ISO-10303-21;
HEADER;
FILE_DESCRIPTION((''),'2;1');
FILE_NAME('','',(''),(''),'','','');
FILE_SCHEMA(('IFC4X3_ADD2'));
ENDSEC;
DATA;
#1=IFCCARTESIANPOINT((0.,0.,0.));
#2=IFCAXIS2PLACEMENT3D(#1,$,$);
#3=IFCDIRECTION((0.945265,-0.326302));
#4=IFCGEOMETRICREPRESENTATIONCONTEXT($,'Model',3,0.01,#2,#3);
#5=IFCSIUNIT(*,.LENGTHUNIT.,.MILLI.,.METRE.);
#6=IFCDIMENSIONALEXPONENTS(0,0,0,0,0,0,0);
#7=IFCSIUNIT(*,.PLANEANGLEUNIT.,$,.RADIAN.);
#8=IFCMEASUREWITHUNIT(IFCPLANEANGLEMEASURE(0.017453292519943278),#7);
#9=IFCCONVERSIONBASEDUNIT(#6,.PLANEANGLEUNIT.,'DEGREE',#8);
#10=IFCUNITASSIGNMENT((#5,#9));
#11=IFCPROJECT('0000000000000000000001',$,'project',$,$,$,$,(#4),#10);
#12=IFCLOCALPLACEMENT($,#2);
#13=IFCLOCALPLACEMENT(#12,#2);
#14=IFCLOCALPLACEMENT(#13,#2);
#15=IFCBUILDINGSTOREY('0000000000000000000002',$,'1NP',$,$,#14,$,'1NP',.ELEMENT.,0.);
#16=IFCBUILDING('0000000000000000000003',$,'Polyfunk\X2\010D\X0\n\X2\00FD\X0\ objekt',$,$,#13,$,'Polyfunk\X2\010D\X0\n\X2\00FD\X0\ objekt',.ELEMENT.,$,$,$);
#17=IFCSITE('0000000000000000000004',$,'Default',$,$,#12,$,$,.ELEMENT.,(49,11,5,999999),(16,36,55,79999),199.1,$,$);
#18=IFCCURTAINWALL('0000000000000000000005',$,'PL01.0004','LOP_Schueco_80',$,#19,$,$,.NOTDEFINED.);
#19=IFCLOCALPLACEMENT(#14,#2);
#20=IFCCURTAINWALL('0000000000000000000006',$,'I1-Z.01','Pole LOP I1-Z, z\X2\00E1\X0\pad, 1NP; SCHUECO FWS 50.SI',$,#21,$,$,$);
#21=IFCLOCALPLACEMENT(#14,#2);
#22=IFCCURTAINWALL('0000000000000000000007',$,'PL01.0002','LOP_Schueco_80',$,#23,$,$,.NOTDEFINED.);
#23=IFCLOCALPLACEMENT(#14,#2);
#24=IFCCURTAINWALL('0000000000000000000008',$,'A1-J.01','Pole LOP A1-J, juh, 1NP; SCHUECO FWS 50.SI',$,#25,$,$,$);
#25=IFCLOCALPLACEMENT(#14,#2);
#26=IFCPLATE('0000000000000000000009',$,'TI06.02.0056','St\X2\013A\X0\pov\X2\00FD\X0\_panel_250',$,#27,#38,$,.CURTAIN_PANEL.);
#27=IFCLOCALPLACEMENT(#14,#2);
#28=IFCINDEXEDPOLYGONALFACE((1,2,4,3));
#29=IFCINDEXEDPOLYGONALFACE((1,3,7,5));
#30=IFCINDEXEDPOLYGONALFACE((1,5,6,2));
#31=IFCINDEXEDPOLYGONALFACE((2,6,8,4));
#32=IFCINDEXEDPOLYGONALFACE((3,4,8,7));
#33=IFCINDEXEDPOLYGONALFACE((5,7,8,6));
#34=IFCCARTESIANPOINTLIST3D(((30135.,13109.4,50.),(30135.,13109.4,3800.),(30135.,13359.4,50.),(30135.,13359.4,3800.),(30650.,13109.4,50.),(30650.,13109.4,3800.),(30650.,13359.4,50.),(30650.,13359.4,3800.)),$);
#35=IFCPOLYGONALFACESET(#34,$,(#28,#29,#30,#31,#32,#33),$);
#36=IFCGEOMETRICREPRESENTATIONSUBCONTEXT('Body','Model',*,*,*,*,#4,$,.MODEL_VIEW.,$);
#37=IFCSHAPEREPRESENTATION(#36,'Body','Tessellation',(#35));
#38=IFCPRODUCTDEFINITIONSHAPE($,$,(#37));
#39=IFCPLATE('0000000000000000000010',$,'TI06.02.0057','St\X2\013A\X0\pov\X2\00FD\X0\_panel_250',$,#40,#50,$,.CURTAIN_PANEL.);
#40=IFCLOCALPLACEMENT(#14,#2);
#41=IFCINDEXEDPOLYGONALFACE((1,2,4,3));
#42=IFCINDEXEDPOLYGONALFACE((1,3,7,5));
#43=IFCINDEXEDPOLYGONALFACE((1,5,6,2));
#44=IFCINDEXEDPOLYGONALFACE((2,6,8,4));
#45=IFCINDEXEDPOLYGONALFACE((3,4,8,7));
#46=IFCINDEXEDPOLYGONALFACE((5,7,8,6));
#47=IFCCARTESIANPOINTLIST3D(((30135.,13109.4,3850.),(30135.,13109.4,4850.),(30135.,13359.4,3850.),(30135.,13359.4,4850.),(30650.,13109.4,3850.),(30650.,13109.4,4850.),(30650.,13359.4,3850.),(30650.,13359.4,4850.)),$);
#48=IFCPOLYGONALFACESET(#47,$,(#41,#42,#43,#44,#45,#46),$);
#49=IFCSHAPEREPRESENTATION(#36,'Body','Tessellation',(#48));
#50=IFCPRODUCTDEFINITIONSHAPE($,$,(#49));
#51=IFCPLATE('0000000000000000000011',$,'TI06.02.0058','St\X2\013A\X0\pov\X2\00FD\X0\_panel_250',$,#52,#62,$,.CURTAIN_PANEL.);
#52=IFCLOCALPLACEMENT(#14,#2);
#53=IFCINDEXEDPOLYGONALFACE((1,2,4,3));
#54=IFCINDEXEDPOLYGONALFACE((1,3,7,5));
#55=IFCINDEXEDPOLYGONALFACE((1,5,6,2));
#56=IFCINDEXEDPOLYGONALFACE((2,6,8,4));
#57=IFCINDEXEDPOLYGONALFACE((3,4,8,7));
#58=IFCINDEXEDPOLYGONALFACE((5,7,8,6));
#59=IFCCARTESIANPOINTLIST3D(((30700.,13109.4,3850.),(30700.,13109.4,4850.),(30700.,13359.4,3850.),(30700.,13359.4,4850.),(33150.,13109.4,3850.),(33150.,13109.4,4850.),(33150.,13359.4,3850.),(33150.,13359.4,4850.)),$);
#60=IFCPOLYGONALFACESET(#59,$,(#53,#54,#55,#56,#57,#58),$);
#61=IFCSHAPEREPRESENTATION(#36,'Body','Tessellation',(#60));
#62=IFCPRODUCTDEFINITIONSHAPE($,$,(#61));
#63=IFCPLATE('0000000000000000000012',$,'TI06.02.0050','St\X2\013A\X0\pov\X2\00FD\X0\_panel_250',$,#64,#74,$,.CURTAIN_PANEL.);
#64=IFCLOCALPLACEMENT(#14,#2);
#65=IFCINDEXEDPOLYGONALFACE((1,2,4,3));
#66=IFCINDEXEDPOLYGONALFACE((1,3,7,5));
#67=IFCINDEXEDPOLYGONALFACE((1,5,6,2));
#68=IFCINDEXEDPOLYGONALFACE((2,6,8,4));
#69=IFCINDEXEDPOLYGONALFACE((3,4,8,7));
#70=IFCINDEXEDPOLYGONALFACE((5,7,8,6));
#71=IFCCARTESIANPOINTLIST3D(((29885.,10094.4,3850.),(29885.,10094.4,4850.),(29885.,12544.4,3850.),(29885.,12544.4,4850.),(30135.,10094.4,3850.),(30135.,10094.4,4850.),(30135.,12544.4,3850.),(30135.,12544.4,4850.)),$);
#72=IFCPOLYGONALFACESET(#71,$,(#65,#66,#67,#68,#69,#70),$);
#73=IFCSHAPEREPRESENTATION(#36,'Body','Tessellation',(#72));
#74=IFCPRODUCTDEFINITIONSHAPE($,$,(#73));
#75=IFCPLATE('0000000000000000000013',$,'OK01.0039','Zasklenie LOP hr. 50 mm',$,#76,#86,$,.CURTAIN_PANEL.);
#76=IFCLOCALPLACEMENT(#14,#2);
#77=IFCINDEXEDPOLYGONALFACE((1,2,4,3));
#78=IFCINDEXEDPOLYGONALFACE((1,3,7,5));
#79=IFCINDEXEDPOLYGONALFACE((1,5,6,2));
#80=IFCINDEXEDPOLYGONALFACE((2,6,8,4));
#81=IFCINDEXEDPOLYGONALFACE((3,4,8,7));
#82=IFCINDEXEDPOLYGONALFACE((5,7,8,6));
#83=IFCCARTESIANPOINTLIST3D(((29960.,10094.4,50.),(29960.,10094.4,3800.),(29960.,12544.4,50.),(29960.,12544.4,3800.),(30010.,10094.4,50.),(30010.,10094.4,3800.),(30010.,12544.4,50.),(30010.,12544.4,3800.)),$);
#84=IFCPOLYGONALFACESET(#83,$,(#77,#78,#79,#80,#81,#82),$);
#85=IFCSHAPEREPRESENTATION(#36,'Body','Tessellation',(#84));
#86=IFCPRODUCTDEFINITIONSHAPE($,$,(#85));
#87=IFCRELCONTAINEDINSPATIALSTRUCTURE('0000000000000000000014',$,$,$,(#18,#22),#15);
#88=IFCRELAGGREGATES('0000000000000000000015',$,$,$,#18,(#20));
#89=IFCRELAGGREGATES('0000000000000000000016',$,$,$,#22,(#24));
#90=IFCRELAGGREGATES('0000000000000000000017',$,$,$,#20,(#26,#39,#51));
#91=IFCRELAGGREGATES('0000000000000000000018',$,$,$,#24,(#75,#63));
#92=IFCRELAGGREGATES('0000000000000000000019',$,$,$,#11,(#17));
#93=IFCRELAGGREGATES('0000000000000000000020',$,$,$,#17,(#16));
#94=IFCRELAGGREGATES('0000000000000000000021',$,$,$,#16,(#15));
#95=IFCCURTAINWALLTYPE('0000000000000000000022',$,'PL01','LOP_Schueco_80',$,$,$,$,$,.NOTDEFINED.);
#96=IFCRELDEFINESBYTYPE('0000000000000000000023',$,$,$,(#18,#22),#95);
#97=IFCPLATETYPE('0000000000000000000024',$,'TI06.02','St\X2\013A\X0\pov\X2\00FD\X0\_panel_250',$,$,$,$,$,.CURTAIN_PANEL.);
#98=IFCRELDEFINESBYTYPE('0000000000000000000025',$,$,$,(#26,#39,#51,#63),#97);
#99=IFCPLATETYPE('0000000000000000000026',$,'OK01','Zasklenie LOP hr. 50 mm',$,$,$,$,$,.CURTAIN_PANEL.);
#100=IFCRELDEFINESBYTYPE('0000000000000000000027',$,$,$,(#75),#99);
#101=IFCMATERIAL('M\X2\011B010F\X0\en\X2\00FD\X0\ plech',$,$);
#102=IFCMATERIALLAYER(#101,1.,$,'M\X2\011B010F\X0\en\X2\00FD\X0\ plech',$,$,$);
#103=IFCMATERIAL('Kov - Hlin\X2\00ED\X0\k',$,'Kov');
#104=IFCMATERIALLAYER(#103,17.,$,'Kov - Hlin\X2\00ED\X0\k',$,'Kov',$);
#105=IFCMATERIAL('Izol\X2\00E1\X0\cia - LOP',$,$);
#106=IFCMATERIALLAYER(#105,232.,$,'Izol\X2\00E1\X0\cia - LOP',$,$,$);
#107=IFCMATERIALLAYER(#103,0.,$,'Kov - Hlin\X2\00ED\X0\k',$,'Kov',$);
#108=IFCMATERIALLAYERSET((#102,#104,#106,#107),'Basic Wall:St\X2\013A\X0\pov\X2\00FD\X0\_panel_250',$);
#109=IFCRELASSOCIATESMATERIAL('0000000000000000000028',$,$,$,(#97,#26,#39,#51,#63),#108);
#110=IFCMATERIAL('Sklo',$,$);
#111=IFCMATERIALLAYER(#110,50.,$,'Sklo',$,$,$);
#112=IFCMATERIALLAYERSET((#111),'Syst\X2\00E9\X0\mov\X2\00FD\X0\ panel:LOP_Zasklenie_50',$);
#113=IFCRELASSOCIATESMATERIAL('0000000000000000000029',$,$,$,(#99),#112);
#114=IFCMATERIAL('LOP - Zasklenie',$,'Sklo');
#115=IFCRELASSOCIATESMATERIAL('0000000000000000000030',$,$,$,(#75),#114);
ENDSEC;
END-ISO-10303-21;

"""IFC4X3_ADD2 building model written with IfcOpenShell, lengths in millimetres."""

from ifc_helpers import new_model, entity, si_unit, converted_unit, direction, frame, frame_2d, origin, place, context, subcontext, project, spatial, rectangle, extrude, source, transform, mapped, material, layer, layer_set, layer_usage, type_object, type_shapes, element, aggregate, save


model = new_model("IFC4X3_ADD2")

# Units and contexts
model_context = context("Model", 3, precision=0.01, world=origin(), true_north=direction((0.945265, -0.326302)))
body_context = subcontext(model_context, "Body", "Model", "MODEL_VIEW")
ifc_project = project(units=[si_unit("LENGTHUNIT", "METRE", prefix="MILLI"), converted_unit("PLANEANGLEUNIT", "DEGREE", entity("IfcPlaneAngleMeasure", 0.017453292519943278), si_unit("PLANEANGLEUNIT", "RADIAN"), dimensions=[0, 0, 0, 0, 0, 0, 0])], contexts=[model_context])

# Site, building, storey
site_placement = place(None, origin())
site = spatial("IfcSite", under=ifc_project, at=site_placement, Name="Default", CompositionType="ELEMENT", RefLatitude=(49, 11, 5, 999999), RefLongitude=(16, 36, 55, 79999), RefElevation=199.1)
building_placement = place(site_placement, origin())
building = spatial("IfcBuilding", under=site, at=building_placement, Name="Polyfunkčný objekt", LongName="Polyfunkčný objekt", CompositionType="ELEMENT")
storey_placement = place(building_placement, origin())
storey = spatial("IfcBuildingStorey", under=building, at=storey_placement, Name="1NP", LongName="1NP", CompositionType="ELEMENT", Elevation=0.0)

# Curtain walls
curtain_wall_type = type_object("IfcCurtainWallType", Name="PL01", Description="LOP_Schueco_80", PredefinedType="NOTDEFINED")
curtain_wall_1_placement = place(storey_placement, origin())
curtain_wall_1 = element("IfcCurtainWall", 1, at=curtain_wall_1_placement, inside=storey, type_object=curtain_wall_type, Name="PL01.0004", Description="LOP_Schueco_80", PredefinedType="NOTDEFINED")
curtain_wall_2 = element("IfcCurtainWall", 2, Name="I1-Z.01", Description="Pole LOP I1-Z, západ, 1NP; SCHUECO FWS 50.SI")
aggregate(curtain_wall_1, [curtain_wall_2])
curtain_wall_3_placement = place(storey_placement, origin())
curtain_wall_3 = element("IfcCurtainWall", 3, at=curtain_wall_3_placement, inside=storey, type_object=curtain_wall_type, Name="PL01.0002", Description="LOP_Schueco_80", PredefinedType="NOTDEFINED")
curtain_wall_4 = element("IfcCurtainWall", 4, Name="A1-J.01", Description="Pole LOP A1-J, juh, 1NP; SCHUECO FWS 50.SI")
aggregate(curtain_wall_3, [curtain_wall_4])

# Plates
ifc_material_1 = material(Name="Měďený plech")
ifc_layer_1 = layer(ifc_material_1, 1.0, Name="Měďený plech")
ifc_material_2 = material(Name="Kov - Hliník", Category="Kov")
ifc_layer_2 = layer(ifc_material_2, 17.0, Name="Kov - Hliník", Category="Kov")
ifc_material_3 = material(Name="Izolácia - LOP")
ifc_layer_3 = layer(ifc_material_3, 232.0, Name="Izolácia - LOP")
ifc_layer_4 = layer(ifc_material_2, 0.0, Name="Kov - Hliník", Category="Kov")
ifc_layer_set_1 = layer_set([ifc_layer_1, ifc_layer_2, ifc_layer_3, ifc_layer_4], Name="Basic Wall:Stĺpový_panel_250")
ifc_layer_usage_1 = layer_usage(ifc_layer_set_1, "AXIS2", "NEGATIVE", 125.0)
plate_type_1 = type_object("IfcPlateType", Name="TI06.02", Description="Stĺpový_panel_250", PredefinedType="CURTAIN_PANEL", material=ifc_layer_set_1)
plate_1_placement = place(storey_placement, frame((30135.0, 13234.4, 50.0)))
plate_1 = element("IfcPlate", 5, at=plate_1_placement, type_object=plate_type_1, material=ifc_layer_usage_1, Name="TI06.02.0056", Description="Stĺpový_panel_250", PredefinedType="CURTAIN_PANEL", context=body_context, shape_type="SweptSolid", body=[
    extrude(rectangle(XDim=250.0, YDim=515.0, at=frame_2d((0.0, 0.0), x_axis=(1.0, 0.0))), frame((257.5, 0.0, 0.0), z_axis=(0.0, 0.0, 1.0), x_axis=(0.0, 1.0, 0.0)), (0.0, 0.0, 1.0), 3750.0),
])
ifc_layer_usage_2 = layer_usage(ifc_layer_set_1, "AXIS2", "NEGATIVE", 125.0)
plate_2_placement = place(storey_placement, frame((30135.0, 13234.4, 3850.0)))
plate_2 = element("IfcPlate", 6, at=plate_2_placement, type_object=plate_type_1, material=ifc_layer_usage_2, Name="TI06.02.0057", Description="Stĺpový_panel_250", PredefinedType="CURTAIN_PANEL", context=body_context, shape_type="SweptSolid", body=[
    extrude(rectangle(XDim=250.0, YDim=515.0, at=frame_2d((0.0, 0.0), x_axis=(1.0, 0.0))), frame((257.5, 0.0, 0.0), z_axis=(0.0, 0.0, 1.0), x_axis=(0.0, 1.0, 0.0)), (0.0, 0.0, 1.0), 1000.0),
])
ifc_layer_usage_3 = layer_usage(ifc_layer_set_1, "AXIS2", "NEGATIVE", 125.0)
plate_3_placement = place(storey_placement, frame((30700.0, 13234.4, 3850.0)))
plate_3 = element("IfcPlate", 7, at=plate_3_placement, type_object=plate_type_1, material=ifc_layer_usage_3, Name="TI06.02.0058", Description="Stĺpový_panel_250", PredefinedType="CURTAIN_PANEL", context=body_context, shape_type="SweptSolid", body=[
    extrude(rectangle(XDim=250.0, YDim=2450.0, at=frame_2d((0.0, 0.0), x_axis=(1.0, 0.0))), frame((1225.0, 0.0, 0.0), z_axis=(0.0, 0.0, 1.0), x_axis=(0.0, 1.0, 0.0)), (0.0, 0.0, 1.0), 1000.0),
])
aggregate(curtain_wall_2, [plate_1, plate_2, plate_3])
ifc_layer_usage_4 = layer_usage(ifc_layer_set_1, "AXIS2", "POSITIVE", -125.0)
plate_4_placement = place(storey_placement, frame((30010.0, 12544.4, 3850.0), z_axis=(0.0, 0.0, 1.0), x_axis=(0.0, -1.0, 0.0)))
plate_4 = element("IfcPlate", 8, at=plate_4_placement, type_object=plate_type_1, material=ifc_layer_usage_4, Name="TI06.02.0050", Description="Stĺpový_panel_250", PredefinedType="CURTAIN_PANEL", context=body_context, shape_type="SweptSolid", body=[
    extrude(rectangle(XDim=250.0, YDim=2450.0, at=frame_2d((0.0, 0.0), x_axis=(1.0, 0.0))), frame((1225.0, 0.0, 0.0), z_axis=(0.0, 0.0, 1.0), x_axis=(0.0, 1.0, 0.0)), (0.0, 0.0, 1.0), 1000.0),
])
ifc_material_4 = material(Name="LOP - Zasklenie", Category="Sklo")
ifc_material_5 = material(Name="Sklo")
ifc_layer_5 = layer(ifc_material_5, 50.0, Name="Sklo")
ifc_layer_set_2 = layer_set([ifc_layer_5], Name="Systémový panel:LOP_Zasklenie_50")
plate_type_2 = type_object("IfcPlateType", Name="OK01", Description="Zasklenie LOP hr. 50 mm", PredefinedType="CURTAIN_PANEL", material=ifc_layer_set_2)
shared_shape_1 = source(origin(), body_context, "Body", "SweptSolid", [
    extrude(rectangle(XDim=3750.0, YDim=2450.0, at=frame_2d((-141.7, 0.0), x_axis=(1.0, 0.0))), frame((0.0, -50.0, 2016.7), z_axis=(0.0, 1.0, 0.0), x_axis=(0.0, 0.0, 1.0)), (0.0, 0.0, 1.0), 50.0),
])
type_shapes(plate_type_2, [shared_shape_1])
plate_5_placement = place(curtain_wall_3_placement, frame((30010.0, 11319.4, 50.0), z_axis=(0.0, 0.0, 1.0), x_axis=(0.0, -1.0, 0.0)))
plate_5 = element("IfcPlate", 9, at=plate_5_placement, type_object=plate_type_2, material=ifc_material_4, Name="OK01.0039", Description="Zasklenie LOP hr. 50 mm", PredefinedType="CURTAIN_PANEL", context=body_context, shape_type="MappedRepresentation", body=[
    mapped(shared_shape_1, transform((0.0, 0.0, 0.0), scale=1.0)),
])
aggregate(curtain_wall_4, [plate_5, plate_4])

save(model, "model.ifc")
